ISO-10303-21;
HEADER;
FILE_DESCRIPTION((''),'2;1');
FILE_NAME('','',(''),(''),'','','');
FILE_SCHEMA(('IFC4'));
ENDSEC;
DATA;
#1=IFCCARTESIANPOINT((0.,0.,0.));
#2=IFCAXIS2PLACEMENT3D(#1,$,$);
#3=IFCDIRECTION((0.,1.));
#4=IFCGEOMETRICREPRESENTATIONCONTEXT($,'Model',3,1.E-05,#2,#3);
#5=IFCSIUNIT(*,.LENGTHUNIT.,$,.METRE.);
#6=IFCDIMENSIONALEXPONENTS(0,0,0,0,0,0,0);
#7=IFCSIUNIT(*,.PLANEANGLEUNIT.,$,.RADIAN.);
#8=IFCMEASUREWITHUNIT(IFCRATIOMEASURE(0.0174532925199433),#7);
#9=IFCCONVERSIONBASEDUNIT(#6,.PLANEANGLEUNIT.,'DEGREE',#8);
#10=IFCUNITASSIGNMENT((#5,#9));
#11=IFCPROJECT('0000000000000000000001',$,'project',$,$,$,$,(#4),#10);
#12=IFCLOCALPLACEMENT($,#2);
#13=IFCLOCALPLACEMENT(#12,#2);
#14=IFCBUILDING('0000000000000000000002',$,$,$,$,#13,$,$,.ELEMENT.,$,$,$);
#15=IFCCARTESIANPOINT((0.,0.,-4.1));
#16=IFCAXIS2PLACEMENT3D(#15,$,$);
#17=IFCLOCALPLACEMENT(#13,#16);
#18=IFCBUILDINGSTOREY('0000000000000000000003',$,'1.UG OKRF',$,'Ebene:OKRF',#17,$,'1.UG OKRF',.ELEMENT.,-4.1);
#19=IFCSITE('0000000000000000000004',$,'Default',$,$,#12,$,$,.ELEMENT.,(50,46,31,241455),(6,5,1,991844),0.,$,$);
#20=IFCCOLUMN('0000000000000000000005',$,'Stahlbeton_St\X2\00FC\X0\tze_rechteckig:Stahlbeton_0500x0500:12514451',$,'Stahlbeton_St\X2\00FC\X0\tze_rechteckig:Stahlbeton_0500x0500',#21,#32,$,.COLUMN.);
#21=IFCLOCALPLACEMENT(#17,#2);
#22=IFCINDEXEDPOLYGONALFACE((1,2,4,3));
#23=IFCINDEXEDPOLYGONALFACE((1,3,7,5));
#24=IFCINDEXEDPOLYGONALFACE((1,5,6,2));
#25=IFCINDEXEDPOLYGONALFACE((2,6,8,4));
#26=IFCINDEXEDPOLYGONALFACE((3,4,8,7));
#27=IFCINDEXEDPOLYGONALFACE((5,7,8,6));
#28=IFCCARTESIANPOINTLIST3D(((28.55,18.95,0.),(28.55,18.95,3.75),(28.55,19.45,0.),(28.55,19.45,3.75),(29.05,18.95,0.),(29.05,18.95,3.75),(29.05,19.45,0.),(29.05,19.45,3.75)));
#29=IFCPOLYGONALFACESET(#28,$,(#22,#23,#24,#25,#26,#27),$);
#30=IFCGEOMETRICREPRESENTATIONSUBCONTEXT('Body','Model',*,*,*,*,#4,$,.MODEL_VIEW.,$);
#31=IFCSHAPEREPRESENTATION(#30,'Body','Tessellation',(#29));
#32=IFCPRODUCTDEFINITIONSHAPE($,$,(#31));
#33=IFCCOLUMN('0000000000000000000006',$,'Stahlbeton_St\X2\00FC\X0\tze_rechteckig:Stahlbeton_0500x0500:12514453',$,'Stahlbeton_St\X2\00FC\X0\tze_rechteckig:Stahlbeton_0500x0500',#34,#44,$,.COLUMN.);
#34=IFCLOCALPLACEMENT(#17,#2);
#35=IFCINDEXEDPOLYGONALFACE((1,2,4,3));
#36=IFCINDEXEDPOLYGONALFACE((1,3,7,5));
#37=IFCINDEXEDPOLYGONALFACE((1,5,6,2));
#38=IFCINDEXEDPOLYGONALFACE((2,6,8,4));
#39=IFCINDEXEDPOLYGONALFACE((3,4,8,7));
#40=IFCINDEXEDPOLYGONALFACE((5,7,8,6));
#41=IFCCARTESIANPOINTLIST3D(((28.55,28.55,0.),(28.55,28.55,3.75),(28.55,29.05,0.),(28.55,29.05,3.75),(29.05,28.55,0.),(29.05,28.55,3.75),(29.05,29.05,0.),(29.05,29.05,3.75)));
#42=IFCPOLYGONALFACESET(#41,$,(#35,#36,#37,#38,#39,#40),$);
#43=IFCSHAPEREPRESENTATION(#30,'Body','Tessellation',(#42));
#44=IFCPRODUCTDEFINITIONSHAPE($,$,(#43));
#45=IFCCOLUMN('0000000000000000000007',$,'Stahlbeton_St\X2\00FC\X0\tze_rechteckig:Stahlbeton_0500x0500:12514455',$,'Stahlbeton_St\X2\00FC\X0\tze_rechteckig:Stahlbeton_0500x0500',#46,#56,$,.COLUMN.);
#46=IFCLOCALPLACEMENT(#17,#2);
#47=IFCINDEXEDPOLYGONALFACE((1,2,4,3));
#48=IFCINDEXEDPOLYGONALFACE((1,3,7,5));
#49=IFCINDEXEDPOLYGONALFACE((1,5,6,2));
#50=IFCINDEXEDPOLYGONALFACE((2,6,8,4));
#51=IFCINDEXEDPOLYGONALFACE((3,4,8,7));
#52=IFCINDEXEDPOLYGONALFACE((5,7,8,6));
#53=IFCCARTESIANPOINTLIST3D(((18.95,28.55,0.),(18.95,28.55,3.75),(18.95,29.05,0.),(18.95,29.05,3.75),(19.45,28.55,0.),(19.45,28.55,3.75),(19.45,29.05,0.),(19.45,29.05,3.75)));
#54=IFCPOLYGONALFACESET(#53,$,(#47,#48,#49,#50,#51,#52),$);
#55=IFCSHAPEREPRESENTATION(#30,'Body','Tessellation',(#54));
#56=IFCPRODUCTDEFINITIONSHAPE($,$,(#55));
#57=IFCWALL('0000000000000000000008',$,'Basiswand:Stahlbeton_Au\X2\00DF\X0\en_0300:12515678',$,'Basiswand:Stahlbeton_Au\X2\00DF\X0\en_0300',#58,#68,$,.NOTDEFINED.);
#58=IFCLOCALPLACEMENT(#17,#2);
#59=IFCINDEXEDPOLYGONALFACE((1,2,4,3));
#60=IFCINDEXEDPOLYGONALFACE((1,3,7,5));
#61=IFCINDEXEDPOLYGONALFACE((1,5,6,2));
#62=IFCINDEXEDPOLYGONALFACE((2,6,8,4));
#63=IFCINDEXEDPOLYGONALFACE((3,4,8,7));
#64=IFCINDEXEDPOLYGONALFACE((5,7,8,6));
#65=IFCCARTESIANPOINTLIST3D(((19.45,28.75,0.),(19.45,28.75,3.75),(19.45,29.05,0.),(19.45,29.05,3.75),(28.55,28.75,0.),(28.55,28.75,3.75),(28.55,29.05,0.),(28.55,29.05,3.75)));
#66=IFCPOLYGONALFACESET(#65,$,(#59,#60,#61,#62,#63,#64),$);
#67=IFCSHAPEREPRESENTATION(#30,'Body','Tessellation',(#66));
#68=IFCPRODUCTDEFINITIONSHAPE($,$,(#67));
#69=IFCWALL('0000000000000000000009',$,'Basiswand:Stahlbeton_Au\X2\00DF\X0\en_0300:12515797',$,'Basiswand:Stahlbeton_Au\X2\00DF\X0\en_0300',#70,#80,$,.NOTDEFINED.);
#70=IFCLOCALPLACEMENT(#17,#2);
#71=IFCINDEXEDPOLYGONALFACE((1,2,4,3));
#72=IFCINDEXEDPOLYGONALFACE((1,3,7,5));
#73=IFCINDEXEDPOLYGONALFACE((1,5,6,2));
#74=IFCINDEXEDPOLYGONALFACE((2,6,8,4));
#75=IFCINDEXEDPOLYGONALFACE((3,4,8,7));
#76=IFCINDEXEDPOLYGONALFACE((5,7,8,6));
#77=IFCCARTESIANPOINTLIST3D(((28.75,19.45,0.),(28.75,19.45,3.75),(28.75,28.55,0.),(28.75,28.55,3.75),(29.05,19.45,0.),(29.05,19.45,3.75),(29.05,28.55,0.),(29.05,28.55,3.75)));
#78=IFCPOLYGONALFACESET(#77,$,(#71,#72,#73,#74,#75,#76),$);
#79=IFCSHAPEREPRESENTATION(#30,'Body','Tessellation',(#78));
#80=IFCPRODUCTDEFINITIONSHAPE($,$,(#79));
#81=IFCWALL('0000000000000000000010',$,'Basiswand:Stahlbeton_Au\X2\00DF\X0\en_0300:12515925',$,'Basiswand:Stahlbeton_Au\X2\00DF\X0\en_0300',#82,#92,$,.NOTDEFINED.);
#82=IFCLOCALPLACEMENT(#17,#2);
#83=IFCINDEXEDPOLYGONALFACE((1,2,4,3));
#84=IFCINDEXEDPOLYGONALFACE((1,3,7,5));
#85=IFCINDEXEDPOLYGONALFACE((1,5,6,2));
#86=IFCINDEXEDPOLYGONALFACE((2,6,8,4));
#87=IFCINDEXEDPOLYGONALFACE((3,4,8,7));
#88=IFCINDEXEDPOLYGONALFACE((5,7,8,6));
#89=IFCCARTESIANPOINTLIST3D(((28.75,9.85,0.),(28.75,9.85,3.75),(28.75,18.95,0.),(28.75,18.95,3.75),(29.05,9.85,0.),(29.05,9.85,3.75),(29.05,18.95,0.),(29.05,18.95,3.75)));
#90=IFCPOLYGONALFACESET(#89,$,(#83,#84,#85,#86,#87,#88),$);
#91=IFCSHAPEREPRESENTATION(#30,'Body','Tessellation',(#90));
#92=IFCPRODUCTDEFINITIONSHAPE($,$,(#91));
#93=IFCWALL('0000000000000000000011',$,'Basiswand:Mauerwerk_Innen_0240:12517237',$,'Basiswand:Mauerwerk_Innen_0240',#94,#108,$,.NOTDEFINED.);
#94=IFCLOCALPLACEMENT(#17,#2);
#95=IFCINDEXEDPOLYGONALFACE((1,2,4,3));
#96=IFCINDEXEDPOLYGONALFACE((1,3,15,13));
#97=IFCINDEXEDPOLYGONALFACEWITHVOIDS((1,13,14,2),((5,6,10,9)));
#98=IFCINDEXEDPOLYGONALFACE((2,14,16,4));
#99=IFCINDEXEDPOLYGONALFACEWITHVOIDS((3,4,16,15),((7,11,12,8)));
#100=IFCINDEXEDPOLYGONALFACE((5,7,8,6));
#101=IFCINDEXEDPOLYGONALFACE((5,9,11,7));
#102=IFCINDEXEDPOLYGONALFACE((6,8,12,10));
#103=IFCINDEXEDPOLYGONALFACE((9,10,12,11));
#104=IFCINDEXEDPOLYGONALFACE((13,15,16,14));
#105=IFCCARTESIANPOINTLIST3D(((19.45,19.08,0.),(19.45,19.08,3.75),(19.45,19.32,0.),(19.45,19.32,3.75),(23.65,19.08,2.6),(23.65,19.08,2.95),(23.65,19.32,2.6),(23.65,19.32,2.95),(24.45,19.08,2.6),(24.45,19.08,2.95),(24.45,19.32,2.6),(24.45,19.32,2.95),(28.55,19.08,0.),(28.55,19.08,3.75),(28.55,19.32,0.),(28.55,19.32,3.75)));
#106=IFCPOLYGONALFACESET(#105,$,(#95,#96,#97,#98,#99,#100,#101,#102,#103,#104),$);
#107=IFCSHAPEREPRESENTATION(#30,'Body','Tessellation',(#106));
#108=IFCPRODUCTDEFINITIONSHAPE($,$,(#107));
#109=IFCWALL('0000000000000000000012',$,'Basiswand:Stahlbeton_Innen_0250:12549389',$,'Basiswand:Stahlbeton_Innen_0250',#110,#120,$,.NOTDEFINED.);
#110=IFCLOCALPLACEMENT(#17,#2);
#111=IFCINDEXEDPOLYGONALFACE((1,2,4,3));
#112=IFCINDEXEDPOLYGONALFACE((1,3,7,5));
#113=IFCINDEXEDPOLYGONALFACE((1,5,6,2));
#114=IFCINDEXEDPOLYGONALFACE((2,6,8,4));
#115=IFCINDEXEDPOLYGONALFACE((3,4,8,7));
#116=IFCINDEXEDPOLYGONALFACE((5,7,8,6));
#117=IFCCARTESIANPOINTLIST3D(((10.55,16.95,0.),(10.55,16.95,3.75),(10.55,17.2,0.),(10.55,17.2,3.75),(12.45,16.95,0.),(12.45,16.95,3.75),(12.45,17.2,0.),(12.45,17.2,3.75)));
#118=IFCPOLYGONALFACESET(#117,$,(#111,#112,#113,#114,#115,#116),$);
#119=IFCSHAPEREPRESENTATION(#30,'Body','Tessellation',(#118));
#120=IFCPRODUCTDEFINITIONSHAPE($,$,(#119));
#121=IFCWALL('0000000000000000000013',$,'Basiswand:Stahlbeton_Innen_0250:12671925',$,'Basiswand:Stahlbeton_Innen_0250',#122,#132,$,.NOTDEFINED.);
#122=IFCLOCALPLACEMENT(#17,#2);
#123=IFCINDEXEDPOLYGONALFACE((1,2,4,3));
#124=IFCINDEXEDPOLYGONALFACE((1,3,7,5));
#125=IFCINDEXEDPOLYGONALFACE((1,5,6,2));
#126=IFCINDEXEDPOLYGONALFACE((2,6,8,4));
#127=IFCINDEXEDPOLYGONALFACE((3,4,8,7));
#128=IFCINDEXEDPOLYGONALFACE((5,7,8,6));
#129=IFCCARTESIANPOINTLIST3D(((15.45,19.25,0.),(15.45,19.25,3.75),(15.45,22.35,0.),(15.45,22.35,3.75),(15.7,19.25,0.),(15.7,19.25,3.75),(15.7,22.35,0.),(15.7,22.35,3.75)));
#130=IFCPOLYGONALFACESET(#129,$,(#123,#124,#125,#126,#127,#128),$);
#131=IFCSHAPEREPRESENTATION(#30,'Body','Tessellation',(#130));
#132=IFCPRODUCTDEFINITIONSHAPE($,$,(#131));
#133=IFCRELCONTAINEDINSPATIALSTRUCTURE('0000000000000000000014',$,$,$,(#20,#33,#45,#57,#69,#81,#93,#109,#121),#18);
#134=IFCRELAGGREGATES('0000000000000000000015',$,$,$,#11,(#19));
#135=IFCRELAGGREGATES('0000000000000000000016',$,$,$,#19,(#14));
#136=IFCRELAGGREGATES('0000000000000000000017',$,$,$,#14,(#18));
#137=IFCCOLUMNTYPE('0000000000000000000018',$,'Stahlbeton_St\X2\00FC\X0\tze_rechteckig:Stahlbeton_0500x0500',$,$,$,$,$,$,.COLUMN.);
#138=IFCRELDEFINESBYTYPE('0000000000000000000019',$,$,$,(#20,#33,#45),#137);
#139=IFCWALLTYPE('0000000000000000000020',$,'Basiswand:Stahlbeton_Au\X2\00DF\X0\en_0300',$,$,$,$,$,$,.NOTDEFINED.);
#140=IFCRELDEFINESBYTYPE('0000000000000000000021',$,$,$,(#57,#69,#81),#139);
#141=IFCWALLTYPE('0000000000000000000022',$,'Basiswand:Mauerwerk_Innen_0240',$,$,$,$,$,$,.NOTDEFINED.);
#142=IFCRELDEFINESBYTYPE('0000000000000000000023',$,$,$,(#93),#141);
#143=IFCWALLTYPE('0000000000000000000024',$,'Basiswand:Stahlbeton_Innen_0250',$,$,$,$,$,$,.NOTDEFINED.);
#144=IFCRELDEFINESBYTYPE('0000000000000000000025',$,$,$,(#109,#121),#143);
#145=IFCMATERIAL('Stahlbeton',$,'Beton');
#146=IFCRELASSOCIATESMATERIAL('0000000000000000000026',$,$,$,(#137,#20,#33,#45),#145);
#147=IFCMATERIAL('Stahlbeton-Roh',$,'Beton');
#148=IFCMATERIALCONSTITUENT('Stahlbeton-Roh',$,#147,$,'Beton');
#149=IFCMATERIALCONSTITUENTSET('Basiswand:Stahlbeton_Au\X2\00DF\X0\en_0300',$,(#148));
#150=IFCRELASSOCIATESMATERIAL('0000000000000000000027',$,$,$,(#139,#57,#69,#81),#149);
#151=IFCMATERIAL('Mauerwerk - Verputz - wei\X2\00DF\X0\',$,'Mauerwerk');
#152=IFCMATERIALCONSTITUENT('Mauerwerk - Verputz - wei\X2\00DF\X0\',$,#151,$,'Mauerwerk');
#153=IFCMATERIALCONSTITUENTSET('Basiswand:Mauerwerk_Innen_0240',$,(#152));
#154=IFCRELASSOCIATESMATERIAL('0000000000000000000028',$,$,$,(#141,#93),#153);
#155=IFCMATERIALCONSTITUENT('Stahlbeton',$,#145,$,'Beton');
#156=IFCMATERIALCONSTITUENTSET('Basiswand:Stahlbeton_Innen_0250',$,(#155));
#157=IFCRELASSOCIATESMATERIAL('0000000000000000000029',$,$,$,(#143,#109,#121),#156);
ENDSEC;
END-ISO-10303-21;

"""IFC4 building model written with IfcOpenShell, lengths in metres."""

from ifc_helpers import new_model, entity, si_unit, converted_unit, direction, frame, origin, place, context, subcontext, project, spatial, indexed_curve, outline, extrude, source, transform, mapped, material, constituent, constituent_set, type_object, type_shapes, element, save


model = new_model("IFC4")

# Units and contexts
model_context = context("Model", 3, precision=1e-05, world=origin(), true_north=direction((0.0, 1.0)))
body_context = subcontext(model_context, "Body", "Model", "MODEL_VIEW")
ifc_project = project(units=[si_unit("LENGTHUNIT", "METRE"), converted_unit("PLANEANGLEUNIT", "DEGREE", entity("IfcRatioMeasure", 0.0174532925199433), si_unit("PLANEANGLEUNIT", "RADIAN"), dimensions=[0, 0, 0, 0, 0, 0, 0])], contexts=[model_context])

# Site, building, storey
site_placement = place(None, origin())
site = spatial("IfcSite", under=ifc_project, at=site_placement, Name="Default", CompositionType="ELEMENT", RefLatitude=(50, 46, 31, 241455), RefLongitude=(6, 5, 1, 991844), RefElevation=0.0)
building_placement = place(site_placement, origin())
building = spatial("IfcBuilding", under=site, at=building_placement, CompositionType="ELEMENT")
storey_placement = place(building_placement, frame((0.0, 0.0, -4.1)))
storey = spatial("IfcBuildingStorey", under=building, at=storey_placement, Name="1.UG OKRF", ObjectType="Ebene:OKRF", LongName="1.UG OKRF", CompositionType="ELEMENT", Elevation=-4.1)

# Columns
ifc_material_1 = material(Name="Stahlbeton", Category="Beton")
column_type = type_object("IfcColumnType", Name="Stahlbeton_Stütze_rechteckig:Stahlbeton_0500x0500", PredefinedType="COLUMN", material=ifc_material_1)
shared_shape = source(origin(), body_context, "Body", "SweptSolid", [
    extrude(outline(indexed_curve([(-0.25, -0.25), (0.25, -0.25), (0.25, 0.25), (-0.25, 0.25), (-0.25, -0.25)], self_intersect=False)), frame((0.0, 0.0, -4.1), z_axis=(0.0, 0.0, 1.0), x_axis=(0.0, -1.0, 0.0)), (0.0, 0.0, 1.0), 3.75),
])
type_shapes(column_type, [shared_shape])
for number, where, name in (
    (1, (28.8, 19.2, 4.1), "Stahlbeton_Stütze_rechteckig:Stahlbeton_0500x0500:12514451"),
    (2, (28.8, 28.8, 4.1), "Stahlbeton_Stütze_rechteckig:Stahlbeton_0500x0500:12514453"),
    (3, (19.2, 28.8, 4.1), "Stahlbeton_Stütze_rechteckig:Stahlbeton_0500x0500:12514455"),
):
    element("IfcColumn", number, at=place(storey_placement, frame(where)), inside=storey, type_object=column_type, material=ifc_material_1, Name=name, ObjectType="Stahlbeton_Stütze_rechteckig:Stahlbeton_0500x0500", PredefinedType="COLUMN", context=body_context, shape_type="MappedRepresentation", body=[
        mapped(shared_shape, transform((0.0, 0.0, 0.0), scale=1.0)),
    ])

# Walls
ifc_material_2 = material(Name="Stahlbeton-Roh", Category="Beton")
ifc_constituent_1 = constituent(ifc_material_2, Name="Stahlbeton-Roh", Category="Beton")
ifc_constituent_set_1 = constituent_set(constituents=[ifc_constituent_1], Name="Basiswand:Stahlbeton_Außen_0300")
wall_type_1 = type_object("IfcWallType", Name="Basiswand:Stahlbeton_Außen_0300", PredefinedType="NOTDEFINED", material=ifc_constituent_set_1)
wall_1_placement = place(storey_placement, frame((19.45, 28.9, 0.0)))
element("IfcWall", 4, at=wall_1_placement, inside=storey, type_object=wall_type_1, material=ifc_constituent_set_1, Name="Basiswand:Stahlbeton_Außen_0300:12515678", ObjectType="Basiswand:Stahlbeton_Außen_0300", PredefinedType="NOTDEFINED", context=body_context, shape_type="SweptSolid", body=[
    extrude(outline(indexed_curve([(-0.15, -4.55), (0.15, -4.55), (0.15, 4.55), (-0.15, 4.55), (-0.15, -4.55)], self_intersect=False)), frame((4.55, 0.0, 0.0), z_axis=(0.0, 0.0, 1.0), x_axis=(0.0, 1.0, 0.0)), (0.0, 0.0, 1.0), 3.75),
])
for number, where, z_axis, x_axis, name in (
    (5, (28.9, 28.55, 0.0), (0.0, 0.0, 1.0), (0.0, -1.0, 0.0), "Basiswand:Stahlbeton_Außen_0300:12515797"),
    (6, (28.9, 18.95, 0.0), (0.0, 0.0, 1.0), (0.0, -1.0, 0.0), "Basiswand:Stahlbeton_Außen_0300:12515925"),
):
    element("IfcWall", number, at=place(storey_placement, frame(where, z_axis=z_axis, x_axis=x_axis)), inside=storey, type_object=wall_type_1, material=ifc_constituent_set_1, Name=name, ObjectType="Basiswand:Stahlbeton_Außen_0300", PredefinedType="NOTDEFINED", context=body_context, shape_type="SweptSolid", body=[
        extrude(outline(indexed_curve([(-0.15, -4.55), (0.15, -4.55), (0.15, 4.55), (-0.15, 4.55), (-0.15, -4.55)], self_intersect=False)), frame((4.55, 0.0, 0.0), z_axis=(0.0, 0.0, 1.0), x_axis=(0.0, 1.0, 0.0)), (0.0, 0.0, 1.0), 3.75),
    ])

# Wall, opening
ifc_material_3 = material(Name="Mauerwerk - Verputz - weiß", Category="Mauerwerk")
ifc_constituent_2 = constituent(ifc_material_3, Name="Mauerwerk - Verputz - weiß", Category="Mauerwerk")
ifc_constituent_set_2 = constituent_set(constituents=[ifc_constituent_2], Name="Basiswand:Mauerwerk_Innen_0240")
wall_type_2 = type_object("IfcWallType", Name="Basiswand:Mauerwerk_Innen_0240", PredefinedType="NOTDEFINED", material=ifc_constituent_set_2)
wall_2_placement = place(storey_placement, frame((19.45, 19.2, 0.0)))
wall_2 = element("IfcWall", 7, at=wall_2_placement, inside=storey, type_object=wall_type_2, material=ifc_constituent_set_2, Name="Basiswand:Mauerwerk_Innen_0240:12517237", ObjectType="Basiswand:Mauerwerk_Innen_0240", PredefinedType="NOTDEFINED", context=body_context, shape_type="SweptSolid", body=[
    extrude(outline(indexed_curve([(-1.875, -4.55), (1.875, -4.55), (1.875, 4.55), (-1.875, 4.55), (-1.875, -4.55)], self_intersect=False), holes=[indexed_curve([(1.075, -0.35), (0.725, -0.35), (0.725, 0.45), (1.075, 0.45), (1.075, -0.35)], self_intersect=False)]), frame((4.55, -0.12, 1.875), z_axis=(0.0, 1.0, 0.0), x_axis=(0.0, 0.0, 1.0)), (0.0, 0.0, 1.0), 0.24),
])
opening_1_placement = place(wall_2_placement, origin())
element("IfcOpeningElement", 8, at=opening_1_placement, cuts=wall_2, ObjectType="Opening", PredefinedType="OPENING", context=body_context, shape_type="SweptSolid", body=[
    extrude(outline(indexed_curve([(-0.175, -0.4), (0.175, -0.4), (0.175, 0.4), (-0.175, 0.4), (-0.175, -0.4)], self_intersect=False)), frame((4.6, -0.12, 2.775), z_axis=(0.0, 1.0, 0.0), x_axis=(0.0, 0.0, -1.0)), (0.0, 0.0, 1.0), 0.24),
])

# Walls
ifc_constituent_3 = constituent(ifc_material_1, Name="Stahlbeton", Category="Beton")
ifc_constituent_set_3 = constituent_set(constituents=[ifc_constituent_3], Name="Basiswand:Stahlbeton_Innen_0250")
wall_type_3 = type_object("IfcWallType", Name="Basiswand:Stahlbeton_Innen_0250", PredefinedType="NOTDEFINED", material=ifc_constituent_set_3)
wall_3_placement = place(storey_placement, frame((12.45, 17.075, 0.0), z_axis=(0.0, 0.0, 1.0), x_axis=(-1.0, 0.0, 0.0)))
element("IfcWall", 9, at=wall_3_placement, inside=storey, type_object=wall_type_3, material=ifc_constituent_set_3, Name="Basiswand:Stahlbeton_Innen_0250:12549389", ObjectType="Basiswand:Stahlbeton_Innen_0250", PredefinedType="NOTDEFINED", context=body_context, shape_type="SweptSolid", body=[
    extrude(outline(indexed_curve([(-0.125, -0.95), (0.125, -0.95), (0.125, 0.95), (-0.125, 0.95), (-0.125, -0.95)], self_intersect=False)), frame((0.95, 0.0, 0.0), z_axis=(0.0, 0.0, 1.0), x_axis=(0.0, 1.0, 0.0)), (0.0, 0.0, 1.0), 3.75),
])
wall_4_placement = place(storey_placement, frame((15.575, 22.35, 0.0), z_axis=(0.0, 0.0, 1.0), x_axis=(0.0, -1.0, 0.0)))
element("IfcWall", 10, at=wall_4_placement, inside=storey, type_object=wall_type_3, material=ifc_constituent_set_3, Name="Basiswand:Stahlbeton_Innen_0250:12671925", ObjectType="Basiswand:Stahlbeton_Innen_0250", PredefinedType="NOTDEFINED", context=body_context, shape_type="SweptSolid", body=[
    extrude(outline(indexed_curve([(-0.125, -1.55), (0.125, -1.55), (0.125, 1.55), (-0.125, 1.55), (-0.125, -1.55)], self_intersect=False)), frame((1.55, 0.0, 0.0), z_axis=(0.0, 0.0, 1.0), x_axis=(0.0, 1.0, 0.0)), (0.0, 0.0, 1.0), 3.75),
])

save(model, "model.ifc")
